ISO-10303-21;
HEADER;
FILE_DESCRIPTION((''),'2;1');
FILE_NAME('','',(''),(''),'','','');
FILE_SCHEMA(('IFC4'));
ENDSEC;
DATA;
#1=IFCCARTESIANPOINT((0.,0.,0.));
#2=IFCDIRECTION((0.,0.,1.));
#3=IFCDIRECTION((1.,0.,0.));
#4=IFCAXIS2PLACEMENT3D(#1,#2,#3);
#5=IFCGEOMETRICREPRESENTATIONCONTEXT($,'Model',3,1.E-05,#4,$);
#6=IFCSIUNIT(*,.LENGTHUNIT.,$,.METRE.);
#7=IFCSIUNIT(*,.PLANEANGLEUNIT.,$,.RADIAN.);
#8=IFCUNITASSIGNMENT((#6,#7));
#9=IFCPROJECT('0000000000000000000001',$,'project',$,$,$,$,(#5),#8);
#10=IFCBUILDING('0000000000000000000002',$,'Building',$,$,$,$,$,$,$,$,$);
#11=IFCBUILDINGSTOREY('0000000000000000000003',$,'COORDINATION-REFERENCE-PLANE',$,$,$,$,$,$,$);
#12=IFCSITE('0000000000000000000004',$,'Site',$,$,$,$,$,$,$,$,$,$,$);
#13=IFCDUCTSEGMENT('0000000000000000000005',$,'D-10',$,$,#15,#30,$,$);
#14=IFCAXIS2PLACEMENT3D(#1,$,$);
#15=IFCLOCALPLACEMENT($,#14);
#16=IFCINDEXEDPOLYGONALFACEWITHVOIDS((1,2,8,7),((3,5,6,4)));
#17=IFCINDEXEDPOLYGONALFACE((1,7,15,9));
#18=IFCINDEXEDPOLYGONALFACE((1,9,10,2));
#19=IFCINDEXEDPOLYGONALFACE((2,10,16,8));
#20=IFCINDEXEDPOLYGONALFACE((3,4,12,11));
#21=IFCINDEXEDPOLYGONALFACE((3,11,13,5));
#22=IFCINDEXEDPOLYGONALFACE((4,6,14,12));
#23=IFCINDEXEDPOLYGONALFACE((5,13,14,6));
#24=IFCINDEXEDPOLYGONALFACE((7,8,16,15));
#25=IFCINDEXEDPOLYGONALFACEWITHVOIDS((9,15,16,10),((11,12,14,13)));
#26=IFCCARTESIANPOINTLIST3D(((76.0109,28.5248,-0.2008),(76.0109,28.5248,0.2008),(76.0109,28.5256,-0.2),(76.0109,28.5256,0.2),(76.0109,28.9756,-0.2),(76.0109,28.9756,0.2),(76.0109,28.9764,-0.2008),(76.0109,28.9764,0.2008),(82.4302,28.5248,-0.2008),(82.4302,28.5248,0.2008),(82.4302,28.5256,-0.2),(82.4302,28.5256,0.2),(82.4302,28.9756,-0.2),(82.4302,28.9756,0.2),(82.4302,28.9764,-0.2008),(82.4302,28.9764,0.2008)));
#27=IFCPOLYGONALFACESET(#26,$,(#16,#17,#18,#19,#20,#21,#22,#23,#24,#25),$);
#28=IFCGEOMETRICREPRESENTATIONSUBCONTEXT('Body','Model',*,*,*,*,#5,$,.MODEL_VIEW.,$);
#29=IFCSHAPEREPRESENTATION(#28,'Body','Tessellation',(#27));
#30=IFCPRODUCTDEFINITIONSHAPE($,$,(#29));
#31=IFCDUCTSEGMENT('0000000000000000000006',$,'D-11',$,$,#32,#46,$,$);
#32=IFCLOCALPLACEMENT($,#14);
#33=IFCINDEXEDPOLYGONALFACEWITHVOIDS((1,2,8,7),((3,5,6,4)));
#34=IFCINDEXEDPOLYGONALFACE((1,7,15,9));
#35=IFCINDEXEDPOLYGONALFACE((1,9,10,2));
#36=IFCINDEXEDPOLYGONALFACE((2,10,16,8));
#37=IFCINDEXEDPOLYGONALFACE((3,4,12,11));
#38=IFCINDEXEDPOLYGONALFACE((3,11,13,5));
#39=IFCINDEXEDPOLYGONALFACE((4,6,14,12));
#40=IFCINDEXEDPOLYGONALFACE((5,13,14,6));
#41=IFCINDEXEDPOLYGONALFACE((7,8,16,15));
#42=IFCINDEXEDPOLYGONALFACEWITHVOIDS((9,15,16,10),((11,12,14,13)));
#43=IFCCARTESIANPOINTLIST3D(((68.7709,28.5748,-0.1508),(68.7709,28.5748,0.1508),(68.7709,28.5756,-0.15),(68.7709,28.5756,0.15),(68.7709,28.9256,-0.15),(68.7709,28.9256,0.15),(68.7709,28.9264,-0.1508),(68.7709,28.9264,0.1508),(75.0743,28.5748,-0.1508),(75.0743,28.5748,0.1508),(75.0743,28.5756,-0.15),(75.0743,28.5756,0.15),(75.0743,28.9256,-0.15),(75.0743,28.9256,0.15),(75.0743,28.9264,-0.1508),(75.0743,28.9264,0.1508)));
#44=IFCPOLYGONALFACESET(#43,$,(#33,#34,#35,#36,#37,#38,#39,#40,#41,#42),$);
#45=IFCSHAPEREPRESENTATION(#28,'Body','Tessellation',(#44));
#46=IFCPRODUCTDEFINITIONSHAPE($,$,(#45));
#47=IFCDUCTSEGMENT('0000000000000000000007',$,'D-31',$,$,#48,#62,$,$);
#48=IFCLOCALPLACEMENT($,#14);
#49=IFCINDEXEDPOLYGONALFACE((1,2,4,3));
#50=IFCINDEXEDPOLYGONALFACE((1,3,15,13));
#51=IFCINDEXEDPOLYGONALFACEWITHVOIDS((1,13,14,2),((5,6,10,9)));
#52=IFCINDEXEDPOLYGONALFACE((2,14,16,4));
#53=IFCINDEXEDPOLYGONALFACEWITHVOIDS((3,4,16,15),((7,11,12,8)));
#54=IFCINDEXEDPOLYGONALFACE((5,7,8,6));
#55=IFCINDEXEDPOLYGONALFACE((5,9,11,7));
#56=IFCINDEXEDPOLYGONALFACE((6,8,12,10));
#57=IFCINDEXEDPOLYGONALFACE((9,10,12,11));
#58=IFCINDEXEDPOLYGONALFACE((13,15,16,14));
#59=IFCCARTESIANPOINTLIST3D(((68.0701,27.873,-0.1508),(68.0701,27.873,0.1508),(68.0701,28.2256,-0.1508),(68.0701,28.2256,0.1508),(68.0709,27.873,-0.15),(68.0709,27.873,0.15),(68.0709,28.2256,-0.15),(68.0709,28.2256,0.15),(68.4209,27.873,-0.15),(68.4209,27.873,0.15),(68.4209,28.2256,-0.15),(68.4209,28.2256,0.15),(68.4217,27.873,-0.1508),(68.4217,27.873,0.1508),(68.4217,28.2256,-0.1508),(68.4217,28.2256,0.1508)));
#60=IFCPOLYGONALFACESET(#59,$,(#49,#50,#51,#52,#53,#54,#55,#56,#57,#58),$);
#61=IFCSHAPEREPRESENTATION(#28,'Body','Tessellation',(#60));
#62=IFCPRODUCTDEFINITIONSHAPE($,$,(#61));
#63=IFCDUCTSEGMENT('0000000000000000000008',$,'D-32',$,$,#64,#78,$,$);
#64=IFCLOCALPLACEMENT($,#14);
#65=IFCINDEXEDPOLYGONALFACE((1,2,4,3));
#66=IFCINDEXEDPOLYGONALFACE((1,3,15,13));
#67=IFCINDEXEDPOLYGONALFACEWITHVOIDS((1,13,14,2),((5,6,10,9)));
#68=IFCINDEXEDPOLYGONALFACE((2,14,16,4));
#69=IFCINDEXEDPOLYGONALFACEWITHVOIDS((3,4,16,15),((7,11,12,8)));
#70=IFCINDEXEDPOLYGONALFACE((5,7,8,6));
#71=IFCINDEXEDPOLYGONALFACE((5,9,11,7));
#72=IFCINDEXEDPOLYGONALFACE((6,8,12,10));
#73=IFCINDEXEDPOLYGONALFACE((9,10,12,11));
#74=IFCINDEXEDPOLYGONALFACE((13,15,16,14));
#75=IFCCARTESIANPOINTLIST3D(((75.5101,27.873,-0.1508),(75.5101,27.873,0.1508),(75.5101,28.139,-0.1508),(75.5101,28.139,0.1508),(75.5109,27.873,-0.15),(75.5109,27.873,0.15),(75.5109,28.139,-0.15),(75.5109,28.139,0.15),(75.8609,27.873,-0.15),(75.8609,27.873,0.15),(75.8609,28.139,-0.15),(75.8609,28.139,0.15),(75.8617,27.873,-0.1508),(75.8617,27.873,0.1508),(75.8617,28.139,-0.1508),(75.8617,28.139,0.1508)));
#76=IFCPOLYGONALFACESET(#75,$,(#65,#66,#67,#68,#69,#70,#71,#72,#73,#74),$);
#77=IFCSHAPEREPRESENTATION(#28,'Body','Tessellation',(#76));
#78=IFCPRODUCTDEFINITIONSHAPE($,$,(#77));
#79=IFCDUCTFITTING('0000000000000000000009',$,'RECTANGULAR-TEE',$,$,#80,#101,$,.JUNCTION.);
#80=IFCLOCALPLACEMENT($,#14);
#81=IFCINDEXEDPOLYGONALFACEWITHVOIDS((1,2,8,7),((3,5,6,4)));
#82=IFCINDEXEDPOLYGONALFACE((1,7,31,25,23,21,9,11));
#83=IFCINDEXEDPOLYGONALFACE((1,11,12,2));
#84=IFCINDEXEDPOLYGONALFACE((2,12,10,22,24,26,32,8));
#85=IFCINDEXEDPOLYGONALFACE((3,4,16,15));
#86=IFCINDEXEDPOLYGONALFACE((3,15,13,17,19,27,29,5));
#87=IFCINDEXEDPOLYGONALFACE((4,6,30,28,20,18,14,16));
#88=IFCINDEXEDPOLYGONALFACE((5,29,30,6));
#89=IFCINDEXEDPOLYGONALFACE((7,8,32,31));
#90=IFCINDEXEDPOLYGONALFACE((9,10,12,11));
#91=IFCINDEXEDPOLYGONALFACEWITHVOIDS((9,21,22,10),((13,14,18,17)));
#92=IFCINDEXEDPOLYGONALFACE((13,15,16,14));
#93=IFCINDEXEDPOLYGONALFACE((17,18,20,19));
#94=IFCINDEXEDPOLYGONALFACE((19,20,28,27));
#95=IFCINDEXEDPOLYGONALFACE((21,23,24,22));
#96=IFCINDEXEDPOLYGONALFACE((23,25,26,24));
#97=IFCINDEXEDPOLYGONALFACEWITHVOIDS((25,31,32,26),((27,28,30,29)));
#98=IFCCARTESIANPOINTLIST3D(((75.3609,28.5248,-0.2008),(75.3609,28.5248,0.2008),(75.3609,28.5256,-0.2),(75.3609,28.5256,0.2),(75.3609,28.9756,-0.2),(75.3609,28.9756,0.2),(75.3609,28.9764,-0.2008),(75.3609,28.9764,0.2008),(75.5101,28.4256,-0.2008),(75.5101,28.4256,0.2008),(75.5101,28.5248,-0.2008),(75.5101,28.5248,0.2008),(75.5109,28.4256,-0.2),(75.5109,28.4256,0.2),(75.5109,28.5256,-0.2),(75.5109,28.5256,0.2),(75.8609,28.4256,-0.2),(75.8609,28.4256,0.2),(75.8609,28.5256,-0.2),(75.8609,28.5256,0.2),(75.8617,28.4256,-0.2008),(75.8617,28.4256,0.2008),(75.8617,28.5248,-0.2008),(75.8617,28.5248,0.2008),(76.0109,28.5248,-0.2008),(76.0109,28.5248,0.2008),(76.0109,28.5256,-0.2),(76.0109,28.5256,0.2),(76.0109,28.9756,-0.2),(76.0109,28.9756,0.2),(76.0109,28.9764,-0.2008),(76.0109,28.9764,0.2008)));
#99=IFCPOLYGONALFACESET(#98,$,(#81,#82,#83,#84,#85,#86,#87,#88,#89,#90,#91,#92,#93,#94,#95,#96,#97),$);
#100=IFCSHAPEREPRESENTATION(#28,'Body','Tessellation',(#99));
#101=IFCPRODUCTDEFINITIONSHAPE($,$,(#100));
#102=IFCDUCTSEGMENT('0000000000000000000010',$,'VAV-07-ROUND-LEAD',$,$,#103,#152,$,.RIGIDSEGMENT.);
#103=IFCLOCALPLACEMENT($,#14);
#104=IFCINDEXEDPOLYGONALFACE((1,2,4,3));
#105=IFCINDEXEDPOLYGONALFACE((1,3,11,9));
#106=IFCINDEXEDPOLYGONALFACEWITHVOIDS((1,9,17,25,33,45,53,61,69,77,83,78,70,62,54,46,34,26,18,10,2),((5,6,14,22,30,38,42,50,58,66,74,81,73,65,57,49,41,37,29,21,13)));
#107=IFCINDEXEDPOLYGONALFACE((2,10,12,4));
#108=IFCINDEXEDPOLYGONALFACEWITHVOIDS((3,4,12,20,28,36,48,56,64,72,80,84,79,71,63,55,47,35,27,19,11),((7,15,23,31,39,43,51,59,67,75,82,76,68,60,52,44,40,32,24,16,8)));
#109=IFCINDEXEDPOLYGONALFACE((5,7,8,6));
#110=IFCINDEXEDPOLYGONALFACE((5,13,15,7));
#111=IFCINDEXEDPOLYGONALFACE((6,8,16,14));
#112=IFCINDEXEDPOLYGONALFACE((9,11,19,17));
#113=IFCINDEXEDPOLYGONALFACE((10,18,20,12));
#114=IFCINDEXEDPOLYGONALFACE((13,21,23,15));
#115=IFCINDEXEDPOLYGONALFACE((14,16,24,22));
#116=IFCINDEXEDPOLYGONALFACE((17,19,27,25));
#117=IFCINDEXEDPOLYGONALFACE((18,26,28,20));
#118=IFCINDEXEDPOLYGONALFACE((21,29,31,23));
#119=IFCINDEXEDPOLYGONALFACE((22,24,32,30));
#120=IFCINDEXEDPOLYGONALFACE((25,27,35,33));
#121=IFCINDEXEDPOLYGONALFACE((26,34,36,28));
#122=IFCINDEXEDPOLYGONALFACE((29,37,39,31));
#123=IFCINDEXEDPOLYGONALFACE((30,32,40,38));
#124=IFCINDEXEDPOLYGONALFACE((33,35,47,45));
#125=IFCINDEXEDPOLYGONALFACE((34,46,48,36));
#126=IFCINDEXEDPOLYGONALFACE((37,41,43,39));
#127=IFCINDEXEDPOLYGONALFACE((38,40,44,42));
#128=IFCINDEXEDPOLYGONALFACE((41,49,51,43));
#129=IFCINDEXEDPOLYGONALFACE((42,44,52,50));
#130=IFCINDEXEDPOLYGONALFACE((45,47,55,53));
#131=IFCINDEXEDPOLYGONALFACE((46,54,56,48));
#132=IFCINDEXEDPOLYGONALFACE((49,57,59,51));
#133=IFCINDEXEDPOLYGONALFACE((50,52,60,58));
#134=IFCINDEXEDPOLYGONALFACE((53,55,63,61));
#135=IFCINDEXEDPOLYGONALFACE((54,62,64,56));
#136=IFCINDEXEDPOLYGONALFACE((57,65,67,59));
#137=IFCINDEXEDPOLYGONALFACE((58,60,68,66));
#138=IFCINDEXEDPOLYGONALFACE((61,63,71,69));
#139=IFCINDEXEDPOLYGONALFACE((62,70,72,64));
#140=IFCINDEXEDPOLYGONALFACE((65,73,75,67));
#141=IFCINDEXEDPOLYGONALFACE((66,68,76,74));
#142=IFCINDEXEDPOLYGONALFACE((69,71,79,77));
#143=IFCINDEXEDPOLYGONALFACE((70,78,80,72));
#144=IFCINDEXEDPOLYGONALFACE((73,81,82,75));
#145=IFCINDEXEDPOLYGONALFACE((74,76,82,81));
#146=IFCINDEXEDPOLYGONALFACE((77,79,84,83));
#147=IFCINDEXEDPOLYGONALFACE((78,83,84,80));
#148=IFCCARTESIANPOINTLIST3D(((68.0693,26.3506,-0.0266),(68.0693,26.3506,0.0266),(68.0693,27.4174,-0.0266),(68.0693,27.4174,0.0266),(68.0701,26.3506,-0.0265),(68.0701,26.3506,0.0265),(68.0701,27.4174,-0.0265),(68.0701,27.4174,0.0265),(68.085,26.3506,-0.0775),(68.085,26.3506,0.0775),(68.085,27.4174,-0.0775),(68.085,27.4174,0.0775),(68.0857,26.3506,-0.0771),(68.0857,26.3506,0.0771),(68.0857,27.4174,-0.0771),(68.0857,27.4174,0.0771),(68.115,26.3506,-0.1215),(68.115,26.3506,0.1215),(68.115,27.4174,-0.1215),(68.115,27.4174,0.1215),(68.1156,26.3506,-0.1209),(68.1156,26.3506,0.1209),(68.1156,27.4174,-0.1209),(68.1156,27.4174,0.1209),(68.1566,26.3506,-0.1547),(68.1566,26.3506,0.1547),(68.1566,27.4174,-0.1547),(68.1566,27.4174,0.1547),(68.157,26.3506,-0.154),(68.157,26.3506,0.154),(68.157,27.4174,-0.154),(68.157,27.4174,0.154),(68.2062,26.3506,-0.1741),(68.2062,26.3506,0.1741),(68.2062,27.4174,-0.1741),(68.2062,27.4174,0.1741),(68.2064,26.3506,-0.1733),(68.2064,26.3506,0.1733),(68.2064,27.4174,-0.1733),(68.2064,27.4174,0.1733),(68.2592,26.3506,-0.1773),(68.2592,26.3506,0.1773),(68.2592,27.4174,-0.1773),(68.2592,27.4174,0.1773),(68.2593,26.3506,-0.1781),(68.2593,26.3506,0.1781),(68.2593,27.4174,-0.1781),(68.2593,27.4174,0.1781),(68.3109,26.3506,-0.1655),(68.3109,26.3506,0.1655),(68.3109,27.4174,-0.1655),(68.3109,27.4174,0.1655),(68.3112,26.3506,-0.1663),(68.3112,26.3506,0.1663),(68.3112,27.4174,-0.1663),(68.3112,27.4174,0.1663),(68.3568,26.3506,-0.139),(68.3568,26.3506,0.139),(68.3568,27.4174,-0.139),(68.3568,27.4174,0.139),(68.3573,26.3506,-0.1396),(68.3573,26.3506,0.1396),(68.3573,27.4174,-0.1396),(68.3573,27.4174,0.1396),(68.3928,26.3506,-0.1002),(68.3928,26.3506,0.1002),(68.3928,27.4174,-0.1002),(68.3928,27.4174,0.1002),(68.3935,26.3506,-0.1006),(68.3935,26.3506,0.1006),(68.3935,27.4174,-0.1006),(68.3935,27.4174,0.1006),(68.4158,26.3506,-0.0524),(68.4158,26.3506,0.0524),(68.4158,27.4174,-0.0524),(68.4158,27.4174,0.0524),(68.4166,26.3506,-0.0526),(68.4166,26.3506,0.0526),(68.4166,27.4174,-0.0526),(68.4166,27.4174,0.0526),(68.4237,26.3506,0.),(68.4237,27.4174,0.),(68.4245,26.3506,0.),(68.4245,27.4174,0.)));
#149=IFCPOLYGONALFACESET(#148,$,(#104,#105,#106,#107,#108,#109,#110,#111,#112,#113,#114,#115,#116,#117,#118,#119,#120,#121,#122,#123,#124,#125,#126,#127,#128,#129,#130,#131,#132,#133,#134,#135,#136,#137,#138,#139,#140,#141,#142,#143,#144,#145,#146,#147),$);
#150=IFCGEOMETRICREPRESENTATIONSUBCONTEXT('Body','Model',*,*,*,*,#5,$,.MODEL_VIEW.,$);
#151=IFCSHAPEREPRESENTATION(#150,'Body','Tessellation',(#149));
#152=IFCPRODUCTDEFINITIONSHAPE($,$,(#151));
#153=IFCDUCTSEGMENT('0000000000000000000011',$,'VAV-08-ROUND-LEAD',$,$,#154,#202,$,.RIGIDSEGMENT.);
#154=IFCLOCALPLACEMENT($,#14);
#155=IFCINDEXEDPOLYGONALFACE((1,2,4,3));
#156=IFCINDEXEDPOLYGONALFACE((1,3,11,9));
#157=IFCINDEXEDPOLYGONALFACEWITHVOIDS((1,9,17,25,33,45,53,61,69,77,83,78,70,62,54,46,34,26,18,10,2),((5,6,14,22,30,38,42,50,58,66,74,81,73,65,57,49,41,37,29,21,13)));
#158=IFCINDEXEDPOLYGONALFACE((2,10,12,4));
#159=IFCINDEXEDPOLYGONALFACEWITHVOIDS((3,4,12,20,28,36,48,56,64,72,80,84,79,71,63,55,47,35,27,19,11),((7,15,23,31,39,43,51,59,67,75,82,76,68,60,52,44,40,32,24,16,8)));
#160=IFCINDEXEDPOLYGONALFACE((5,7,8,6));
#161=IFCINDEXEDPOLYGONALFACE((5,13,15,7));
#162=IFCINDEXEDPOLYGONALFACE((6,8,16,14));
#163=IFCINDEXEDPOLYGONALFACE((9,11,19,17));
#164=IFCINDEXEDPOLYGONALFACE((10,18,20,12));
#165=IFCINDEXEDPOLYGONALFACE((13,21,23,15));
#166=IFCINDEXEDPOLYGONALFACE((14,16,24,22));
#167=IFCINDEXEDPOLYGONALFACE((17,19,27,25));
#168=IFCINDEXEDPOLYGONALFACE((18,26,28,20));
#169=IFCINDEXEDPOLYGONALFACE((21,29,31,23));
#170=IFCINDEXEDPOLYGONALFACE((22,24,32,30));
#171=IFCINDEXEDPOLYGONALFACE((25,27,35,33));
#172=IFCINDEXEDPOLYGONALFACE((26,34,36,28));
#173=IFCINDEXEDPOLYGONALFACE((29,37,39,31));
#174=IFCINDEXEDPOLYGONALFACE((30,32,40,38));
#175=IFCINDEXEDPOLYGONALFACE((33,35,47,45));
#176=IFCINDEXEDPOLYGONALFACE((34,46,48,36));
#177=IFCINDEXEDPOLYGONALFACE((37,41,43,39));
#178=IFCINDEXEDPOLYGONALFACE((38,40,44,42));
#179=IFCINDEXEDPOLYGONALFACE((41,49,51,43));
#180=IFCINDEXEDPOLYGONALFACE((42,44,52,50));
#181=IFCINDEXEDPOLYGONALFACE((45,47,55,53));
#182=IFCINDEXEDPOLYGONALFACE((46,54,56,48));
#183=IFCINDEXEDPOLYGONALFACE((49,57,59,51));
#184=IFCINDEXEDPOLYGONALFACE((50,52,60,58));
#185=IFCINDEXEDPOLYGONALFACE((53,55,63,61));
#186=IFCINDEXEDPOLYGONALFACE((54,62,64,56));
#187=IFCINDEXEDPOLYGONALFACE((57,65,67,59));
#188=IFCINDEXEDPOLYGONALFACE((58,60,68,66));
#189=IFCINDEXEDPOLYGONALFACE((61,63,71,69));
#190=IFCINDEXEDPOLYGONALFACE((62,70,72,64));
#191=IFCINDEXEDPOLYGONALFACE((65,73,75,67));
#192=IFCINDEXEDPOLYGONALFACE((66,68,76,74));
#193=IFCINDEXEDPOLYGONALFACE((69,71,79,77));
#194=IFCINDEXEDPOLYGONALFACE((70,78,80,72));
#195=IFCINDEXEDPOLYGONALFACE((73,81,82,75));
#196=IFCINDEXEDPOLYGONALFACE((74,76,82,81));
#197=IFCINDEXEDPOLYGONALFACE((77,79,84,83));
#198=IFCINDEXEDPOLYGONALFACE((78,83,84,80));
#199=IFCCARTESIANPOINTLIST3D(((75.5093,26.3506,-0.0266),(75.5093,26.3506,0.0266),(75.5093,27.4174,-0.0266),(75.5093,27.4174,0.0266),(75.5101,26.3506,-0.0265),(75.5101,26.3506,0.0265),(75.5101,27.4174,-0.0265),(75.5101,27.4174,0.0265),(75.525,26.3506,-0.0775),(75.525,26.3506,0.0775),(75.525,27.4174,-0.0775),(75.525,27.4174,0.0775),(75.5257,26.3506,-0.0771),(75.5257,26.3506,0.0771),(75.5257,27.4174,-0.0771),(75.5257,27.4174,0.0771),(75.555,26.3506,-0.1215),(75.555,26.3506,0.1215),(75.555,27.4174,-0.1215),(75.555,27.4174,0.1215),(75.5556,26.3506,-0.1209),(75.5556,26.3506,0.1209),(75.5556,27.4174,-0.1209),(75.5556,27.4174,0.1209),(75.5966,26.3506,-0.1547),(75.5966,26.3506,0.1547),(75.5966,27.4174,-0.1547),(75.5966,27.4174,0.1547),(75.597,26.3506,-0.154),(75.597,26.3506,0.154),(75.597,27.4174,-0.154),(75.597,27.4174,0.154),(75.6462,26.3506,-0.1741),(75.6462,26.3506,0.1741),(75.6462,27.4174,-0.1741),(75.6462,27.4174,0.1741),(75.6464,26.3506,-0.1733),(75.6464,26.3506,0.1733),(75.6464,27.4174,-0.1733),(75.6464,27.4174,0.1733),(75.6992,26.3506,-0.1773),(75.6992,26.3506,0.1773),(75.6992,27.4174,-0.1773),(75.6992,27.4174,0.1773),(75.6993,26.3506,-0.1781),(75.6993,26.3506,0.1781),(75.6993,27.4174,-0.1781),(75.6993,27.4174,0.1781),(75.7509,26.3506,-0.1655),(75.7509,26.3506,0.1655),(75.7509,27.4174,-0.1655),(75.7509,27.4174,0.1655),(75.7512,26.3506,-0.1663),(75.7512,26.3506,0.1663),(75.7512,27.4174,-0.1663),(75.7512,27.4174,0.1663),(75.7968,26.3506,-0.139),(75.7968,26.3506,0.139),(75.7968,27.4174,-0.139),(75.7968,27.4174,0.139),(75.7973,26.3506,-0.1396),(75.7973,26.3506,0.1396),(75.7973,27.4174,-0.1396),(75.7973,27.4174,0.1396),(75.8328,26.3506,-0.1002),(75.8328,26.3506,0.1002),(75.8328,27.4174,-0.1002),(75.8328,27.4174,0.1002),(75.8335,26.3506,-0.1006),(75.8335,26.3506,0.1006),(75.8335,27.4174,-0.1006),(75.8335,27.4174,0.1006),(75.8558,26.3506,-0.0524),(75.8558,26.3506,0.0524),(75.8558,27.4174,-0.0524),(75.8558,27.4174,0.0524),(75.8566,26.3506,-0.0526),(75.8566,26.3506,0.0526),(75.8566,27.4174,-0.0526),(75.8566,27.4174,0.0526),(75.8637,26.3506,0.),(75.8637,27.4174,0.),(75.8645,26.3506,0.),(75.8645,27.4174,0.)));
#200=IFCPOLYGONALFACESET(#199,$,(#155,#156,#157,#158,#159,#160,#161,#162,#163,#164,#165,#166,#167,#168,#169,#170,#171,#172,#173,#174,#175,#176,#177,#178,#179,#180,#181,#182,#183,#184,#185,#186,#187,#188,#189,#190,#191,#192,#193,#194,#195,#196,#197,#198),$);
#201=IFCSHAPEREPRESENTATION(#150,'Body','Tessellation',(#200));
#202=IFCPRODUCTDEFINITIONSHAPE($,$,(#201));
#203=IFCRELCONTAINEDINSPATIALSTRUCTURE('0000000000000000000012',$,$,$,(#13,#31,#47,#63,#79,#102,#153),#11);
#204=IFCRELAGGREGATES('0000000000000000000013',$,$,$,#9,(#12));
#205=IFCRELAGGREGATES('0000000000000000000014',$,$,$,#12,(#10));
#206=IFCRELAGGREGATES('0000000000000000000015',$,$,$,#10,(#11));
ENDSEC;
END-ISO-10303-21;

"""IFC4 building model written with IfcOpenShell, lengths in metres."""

from ifc_helpers import new_model, si_unit, frame, origin, origin_with_axes, place, context, subcontext, project, spatial, rectangle, hollow_rectangle, hollow_circle, extrude, boolean, element, save


model = new_model("IFC4")

# Units and contexts
model_context = context("Model", 3, precision=1e-05, world=origin_with_axes())
body_context_1 = subcontext(model_context, "Body", "Model", "MODEL_VIEW")
body_context_2 = subcontext(model_context, "Body", "Model", "MODEL_VIEW")
ifc_project = project(units=[si_unit("LENGTHUNIT", "METRE"), si_unit("PLANEANGLEUNIT", "RADIAN")], contexts=[model_context])

# Site, building, storey
site = spatial("IfcSite", under=ifc_project, Name="Site")
building = spatial("IfcBuilding", under=site, Name="Building")
storey = spatial("IfcBuildingStorey", under=building, Name="COORDINATION-REFERENCE-PLANE")

# Duct segments
duct_segment_1_placement = place(None, frame((76.0109, 28.7506, 0.0), z_axis=(1.0, 0.0, 0.0), x_axis=(0.0, 1.0, 0.0)))
element("IfcDuctSegment", 1, at=duct_segment_1_placement, inside=storey, Name="D-10", context=body_context_1, shape_type="SweptSolid", body=[
    extrude(hollow_rectangle(XDim=0.4516, YDim=0.4016, WallThickness=0.0008), origin(), (0.0, 0.0, 1.0), 6.4193),
])
duct_segment_2_placement = place(None, frame((68.7709, 28.7506, 0.0), z_axis=(1.0, 0.0, 0.0), x_axis=(0.0, 1.0, 0.0)))
element("IfcDuctSegment", 2, at=duct_segment_2_placement, inside=storey, Name="D-11", context=body_context_1, shape_type="SweptSolid", body=[
    extrude(hollow_rectangle(XDim=0.3516, YDim=0.3016, WallThickness=0.0008), origin(), (0.0, 0.0, 1.0), 6.3034),
])
duct_segment_3_placement = place(None, frame((68.2459, 27.873, 0.0), z_axis=(0.0, 1.0, 0.0), x_axis=(1.0, 0.0, 0.0)))
element("IfcDuctSegment", 3, at=duct_segment_3_placement, inside=storey, Name="D-31", context=body_context_1, shape_type="SweptSolid", body=[
    extrude(hollow_rectangle(XDim=0.3516, YDim=0.3016, WallThickness=0.0008), origin(), (0.0, 0.0, 1.0), 0.3526),
])
duct_segment_4_placement = place(None, frame((75.6859, 27.873, 0.0), z_axis=(0.0, 1.0, 0.0), x_axis=(1.0, 0.0, 0.0)))
element("IfcDuctSegment", 4, at=duct_segment_4_placement, inside=storey, Name="D-32", context=body_context_1, shape_type="SweptSolid", body=[
    extrude(hollow_rectangle(XDim=0.3516, YDim=0.3016, WallThickness=0.0008), origin(), (0.0, 0.0, 1.0), 0.266),
])

# Duct fitting
duct_fitting_1_placement = place(None, frame((75.6859, 28.7506, 0.0), z_axis=(-1.0, 0.0, 0.0), x_axis=(0.0, -1.0, 0.0)))
solid_1 = boolean("UNION", extrude(rectangle(XDim=0.45, YDim=0.4), frame((0.0, 0.0, -0.325), z_axis=(0.0, 0.0, 1.0), x_axis=(1.0, 0.0, 0.0)), (0.0, 0.0, 1.0), 0.65), extrude(rectangle(XDim=0.35, YDim=0.4), frame((0.0, 0.0, 0.0), z_axis=(1.0, 0.0, 0.0), x_axis=(0.0, 0.0, -1.0)), (0.0, 0.0, 1.0), 0.325))
element("IfcDuctFitting", 5, at=duct_fitting_1_placement, inside=storey, Name="RECTANGULAR-TEE", PredefinedType="JUNCTION", context=body_context_1, shape_type="CSG", body=[
    boolean("DIFFERENCE", boolean("UNION", extrude(rectangle(XDim=0.4516, YDim=0.4016), frame((0.0, 0.0, -0.325), z_axis=(0.0, 0.0, 1.0), x_axis=(1.0, 0.0, 0.0)), (0.0, 0.0, 1.0), 0.65), extrude(rectangle(XDim=0.3516, YDim=0.4016), frame((0.0, 0.0, 0.0), z_axis=(1.0, 0.0, 0.0), x_axis=(0.0, 0.0, -1.0)), (0.0, 0.0, 1.0), 0.325)), solid_1),
])

# Duct segments
for number, where, z_axis, x_axis, name in (
    (6, (68.2459, 27.4174, 0.0), (0.0, -1.0, 0.0), (1.0, 0.0, 0.0), "VAV-07-ROUND-LEAD"),
    (7, (75.6859, 27.4174, 0.0), (0.0, -1.0, 0.0), (1.0, 0.0, 0.0), "VAV-08-ROUND-LEAD"),
):
    element("IfcDuctSegment", number, at=place(None, frame(where, z_axis=z_axis, x_axis=x_axis)), inside=storey, Name=name, PredefinedType="RIGIDSEGMENT", context=body_context_2, shape_type="SweptSolid", body=[
        extrude(hollow_circle(Radius=0.1786, WallThickness=0.0008), origin(), (0.0, 0.0, 1.0), 1.0668),
    ])

save(model, "model.ifc")
